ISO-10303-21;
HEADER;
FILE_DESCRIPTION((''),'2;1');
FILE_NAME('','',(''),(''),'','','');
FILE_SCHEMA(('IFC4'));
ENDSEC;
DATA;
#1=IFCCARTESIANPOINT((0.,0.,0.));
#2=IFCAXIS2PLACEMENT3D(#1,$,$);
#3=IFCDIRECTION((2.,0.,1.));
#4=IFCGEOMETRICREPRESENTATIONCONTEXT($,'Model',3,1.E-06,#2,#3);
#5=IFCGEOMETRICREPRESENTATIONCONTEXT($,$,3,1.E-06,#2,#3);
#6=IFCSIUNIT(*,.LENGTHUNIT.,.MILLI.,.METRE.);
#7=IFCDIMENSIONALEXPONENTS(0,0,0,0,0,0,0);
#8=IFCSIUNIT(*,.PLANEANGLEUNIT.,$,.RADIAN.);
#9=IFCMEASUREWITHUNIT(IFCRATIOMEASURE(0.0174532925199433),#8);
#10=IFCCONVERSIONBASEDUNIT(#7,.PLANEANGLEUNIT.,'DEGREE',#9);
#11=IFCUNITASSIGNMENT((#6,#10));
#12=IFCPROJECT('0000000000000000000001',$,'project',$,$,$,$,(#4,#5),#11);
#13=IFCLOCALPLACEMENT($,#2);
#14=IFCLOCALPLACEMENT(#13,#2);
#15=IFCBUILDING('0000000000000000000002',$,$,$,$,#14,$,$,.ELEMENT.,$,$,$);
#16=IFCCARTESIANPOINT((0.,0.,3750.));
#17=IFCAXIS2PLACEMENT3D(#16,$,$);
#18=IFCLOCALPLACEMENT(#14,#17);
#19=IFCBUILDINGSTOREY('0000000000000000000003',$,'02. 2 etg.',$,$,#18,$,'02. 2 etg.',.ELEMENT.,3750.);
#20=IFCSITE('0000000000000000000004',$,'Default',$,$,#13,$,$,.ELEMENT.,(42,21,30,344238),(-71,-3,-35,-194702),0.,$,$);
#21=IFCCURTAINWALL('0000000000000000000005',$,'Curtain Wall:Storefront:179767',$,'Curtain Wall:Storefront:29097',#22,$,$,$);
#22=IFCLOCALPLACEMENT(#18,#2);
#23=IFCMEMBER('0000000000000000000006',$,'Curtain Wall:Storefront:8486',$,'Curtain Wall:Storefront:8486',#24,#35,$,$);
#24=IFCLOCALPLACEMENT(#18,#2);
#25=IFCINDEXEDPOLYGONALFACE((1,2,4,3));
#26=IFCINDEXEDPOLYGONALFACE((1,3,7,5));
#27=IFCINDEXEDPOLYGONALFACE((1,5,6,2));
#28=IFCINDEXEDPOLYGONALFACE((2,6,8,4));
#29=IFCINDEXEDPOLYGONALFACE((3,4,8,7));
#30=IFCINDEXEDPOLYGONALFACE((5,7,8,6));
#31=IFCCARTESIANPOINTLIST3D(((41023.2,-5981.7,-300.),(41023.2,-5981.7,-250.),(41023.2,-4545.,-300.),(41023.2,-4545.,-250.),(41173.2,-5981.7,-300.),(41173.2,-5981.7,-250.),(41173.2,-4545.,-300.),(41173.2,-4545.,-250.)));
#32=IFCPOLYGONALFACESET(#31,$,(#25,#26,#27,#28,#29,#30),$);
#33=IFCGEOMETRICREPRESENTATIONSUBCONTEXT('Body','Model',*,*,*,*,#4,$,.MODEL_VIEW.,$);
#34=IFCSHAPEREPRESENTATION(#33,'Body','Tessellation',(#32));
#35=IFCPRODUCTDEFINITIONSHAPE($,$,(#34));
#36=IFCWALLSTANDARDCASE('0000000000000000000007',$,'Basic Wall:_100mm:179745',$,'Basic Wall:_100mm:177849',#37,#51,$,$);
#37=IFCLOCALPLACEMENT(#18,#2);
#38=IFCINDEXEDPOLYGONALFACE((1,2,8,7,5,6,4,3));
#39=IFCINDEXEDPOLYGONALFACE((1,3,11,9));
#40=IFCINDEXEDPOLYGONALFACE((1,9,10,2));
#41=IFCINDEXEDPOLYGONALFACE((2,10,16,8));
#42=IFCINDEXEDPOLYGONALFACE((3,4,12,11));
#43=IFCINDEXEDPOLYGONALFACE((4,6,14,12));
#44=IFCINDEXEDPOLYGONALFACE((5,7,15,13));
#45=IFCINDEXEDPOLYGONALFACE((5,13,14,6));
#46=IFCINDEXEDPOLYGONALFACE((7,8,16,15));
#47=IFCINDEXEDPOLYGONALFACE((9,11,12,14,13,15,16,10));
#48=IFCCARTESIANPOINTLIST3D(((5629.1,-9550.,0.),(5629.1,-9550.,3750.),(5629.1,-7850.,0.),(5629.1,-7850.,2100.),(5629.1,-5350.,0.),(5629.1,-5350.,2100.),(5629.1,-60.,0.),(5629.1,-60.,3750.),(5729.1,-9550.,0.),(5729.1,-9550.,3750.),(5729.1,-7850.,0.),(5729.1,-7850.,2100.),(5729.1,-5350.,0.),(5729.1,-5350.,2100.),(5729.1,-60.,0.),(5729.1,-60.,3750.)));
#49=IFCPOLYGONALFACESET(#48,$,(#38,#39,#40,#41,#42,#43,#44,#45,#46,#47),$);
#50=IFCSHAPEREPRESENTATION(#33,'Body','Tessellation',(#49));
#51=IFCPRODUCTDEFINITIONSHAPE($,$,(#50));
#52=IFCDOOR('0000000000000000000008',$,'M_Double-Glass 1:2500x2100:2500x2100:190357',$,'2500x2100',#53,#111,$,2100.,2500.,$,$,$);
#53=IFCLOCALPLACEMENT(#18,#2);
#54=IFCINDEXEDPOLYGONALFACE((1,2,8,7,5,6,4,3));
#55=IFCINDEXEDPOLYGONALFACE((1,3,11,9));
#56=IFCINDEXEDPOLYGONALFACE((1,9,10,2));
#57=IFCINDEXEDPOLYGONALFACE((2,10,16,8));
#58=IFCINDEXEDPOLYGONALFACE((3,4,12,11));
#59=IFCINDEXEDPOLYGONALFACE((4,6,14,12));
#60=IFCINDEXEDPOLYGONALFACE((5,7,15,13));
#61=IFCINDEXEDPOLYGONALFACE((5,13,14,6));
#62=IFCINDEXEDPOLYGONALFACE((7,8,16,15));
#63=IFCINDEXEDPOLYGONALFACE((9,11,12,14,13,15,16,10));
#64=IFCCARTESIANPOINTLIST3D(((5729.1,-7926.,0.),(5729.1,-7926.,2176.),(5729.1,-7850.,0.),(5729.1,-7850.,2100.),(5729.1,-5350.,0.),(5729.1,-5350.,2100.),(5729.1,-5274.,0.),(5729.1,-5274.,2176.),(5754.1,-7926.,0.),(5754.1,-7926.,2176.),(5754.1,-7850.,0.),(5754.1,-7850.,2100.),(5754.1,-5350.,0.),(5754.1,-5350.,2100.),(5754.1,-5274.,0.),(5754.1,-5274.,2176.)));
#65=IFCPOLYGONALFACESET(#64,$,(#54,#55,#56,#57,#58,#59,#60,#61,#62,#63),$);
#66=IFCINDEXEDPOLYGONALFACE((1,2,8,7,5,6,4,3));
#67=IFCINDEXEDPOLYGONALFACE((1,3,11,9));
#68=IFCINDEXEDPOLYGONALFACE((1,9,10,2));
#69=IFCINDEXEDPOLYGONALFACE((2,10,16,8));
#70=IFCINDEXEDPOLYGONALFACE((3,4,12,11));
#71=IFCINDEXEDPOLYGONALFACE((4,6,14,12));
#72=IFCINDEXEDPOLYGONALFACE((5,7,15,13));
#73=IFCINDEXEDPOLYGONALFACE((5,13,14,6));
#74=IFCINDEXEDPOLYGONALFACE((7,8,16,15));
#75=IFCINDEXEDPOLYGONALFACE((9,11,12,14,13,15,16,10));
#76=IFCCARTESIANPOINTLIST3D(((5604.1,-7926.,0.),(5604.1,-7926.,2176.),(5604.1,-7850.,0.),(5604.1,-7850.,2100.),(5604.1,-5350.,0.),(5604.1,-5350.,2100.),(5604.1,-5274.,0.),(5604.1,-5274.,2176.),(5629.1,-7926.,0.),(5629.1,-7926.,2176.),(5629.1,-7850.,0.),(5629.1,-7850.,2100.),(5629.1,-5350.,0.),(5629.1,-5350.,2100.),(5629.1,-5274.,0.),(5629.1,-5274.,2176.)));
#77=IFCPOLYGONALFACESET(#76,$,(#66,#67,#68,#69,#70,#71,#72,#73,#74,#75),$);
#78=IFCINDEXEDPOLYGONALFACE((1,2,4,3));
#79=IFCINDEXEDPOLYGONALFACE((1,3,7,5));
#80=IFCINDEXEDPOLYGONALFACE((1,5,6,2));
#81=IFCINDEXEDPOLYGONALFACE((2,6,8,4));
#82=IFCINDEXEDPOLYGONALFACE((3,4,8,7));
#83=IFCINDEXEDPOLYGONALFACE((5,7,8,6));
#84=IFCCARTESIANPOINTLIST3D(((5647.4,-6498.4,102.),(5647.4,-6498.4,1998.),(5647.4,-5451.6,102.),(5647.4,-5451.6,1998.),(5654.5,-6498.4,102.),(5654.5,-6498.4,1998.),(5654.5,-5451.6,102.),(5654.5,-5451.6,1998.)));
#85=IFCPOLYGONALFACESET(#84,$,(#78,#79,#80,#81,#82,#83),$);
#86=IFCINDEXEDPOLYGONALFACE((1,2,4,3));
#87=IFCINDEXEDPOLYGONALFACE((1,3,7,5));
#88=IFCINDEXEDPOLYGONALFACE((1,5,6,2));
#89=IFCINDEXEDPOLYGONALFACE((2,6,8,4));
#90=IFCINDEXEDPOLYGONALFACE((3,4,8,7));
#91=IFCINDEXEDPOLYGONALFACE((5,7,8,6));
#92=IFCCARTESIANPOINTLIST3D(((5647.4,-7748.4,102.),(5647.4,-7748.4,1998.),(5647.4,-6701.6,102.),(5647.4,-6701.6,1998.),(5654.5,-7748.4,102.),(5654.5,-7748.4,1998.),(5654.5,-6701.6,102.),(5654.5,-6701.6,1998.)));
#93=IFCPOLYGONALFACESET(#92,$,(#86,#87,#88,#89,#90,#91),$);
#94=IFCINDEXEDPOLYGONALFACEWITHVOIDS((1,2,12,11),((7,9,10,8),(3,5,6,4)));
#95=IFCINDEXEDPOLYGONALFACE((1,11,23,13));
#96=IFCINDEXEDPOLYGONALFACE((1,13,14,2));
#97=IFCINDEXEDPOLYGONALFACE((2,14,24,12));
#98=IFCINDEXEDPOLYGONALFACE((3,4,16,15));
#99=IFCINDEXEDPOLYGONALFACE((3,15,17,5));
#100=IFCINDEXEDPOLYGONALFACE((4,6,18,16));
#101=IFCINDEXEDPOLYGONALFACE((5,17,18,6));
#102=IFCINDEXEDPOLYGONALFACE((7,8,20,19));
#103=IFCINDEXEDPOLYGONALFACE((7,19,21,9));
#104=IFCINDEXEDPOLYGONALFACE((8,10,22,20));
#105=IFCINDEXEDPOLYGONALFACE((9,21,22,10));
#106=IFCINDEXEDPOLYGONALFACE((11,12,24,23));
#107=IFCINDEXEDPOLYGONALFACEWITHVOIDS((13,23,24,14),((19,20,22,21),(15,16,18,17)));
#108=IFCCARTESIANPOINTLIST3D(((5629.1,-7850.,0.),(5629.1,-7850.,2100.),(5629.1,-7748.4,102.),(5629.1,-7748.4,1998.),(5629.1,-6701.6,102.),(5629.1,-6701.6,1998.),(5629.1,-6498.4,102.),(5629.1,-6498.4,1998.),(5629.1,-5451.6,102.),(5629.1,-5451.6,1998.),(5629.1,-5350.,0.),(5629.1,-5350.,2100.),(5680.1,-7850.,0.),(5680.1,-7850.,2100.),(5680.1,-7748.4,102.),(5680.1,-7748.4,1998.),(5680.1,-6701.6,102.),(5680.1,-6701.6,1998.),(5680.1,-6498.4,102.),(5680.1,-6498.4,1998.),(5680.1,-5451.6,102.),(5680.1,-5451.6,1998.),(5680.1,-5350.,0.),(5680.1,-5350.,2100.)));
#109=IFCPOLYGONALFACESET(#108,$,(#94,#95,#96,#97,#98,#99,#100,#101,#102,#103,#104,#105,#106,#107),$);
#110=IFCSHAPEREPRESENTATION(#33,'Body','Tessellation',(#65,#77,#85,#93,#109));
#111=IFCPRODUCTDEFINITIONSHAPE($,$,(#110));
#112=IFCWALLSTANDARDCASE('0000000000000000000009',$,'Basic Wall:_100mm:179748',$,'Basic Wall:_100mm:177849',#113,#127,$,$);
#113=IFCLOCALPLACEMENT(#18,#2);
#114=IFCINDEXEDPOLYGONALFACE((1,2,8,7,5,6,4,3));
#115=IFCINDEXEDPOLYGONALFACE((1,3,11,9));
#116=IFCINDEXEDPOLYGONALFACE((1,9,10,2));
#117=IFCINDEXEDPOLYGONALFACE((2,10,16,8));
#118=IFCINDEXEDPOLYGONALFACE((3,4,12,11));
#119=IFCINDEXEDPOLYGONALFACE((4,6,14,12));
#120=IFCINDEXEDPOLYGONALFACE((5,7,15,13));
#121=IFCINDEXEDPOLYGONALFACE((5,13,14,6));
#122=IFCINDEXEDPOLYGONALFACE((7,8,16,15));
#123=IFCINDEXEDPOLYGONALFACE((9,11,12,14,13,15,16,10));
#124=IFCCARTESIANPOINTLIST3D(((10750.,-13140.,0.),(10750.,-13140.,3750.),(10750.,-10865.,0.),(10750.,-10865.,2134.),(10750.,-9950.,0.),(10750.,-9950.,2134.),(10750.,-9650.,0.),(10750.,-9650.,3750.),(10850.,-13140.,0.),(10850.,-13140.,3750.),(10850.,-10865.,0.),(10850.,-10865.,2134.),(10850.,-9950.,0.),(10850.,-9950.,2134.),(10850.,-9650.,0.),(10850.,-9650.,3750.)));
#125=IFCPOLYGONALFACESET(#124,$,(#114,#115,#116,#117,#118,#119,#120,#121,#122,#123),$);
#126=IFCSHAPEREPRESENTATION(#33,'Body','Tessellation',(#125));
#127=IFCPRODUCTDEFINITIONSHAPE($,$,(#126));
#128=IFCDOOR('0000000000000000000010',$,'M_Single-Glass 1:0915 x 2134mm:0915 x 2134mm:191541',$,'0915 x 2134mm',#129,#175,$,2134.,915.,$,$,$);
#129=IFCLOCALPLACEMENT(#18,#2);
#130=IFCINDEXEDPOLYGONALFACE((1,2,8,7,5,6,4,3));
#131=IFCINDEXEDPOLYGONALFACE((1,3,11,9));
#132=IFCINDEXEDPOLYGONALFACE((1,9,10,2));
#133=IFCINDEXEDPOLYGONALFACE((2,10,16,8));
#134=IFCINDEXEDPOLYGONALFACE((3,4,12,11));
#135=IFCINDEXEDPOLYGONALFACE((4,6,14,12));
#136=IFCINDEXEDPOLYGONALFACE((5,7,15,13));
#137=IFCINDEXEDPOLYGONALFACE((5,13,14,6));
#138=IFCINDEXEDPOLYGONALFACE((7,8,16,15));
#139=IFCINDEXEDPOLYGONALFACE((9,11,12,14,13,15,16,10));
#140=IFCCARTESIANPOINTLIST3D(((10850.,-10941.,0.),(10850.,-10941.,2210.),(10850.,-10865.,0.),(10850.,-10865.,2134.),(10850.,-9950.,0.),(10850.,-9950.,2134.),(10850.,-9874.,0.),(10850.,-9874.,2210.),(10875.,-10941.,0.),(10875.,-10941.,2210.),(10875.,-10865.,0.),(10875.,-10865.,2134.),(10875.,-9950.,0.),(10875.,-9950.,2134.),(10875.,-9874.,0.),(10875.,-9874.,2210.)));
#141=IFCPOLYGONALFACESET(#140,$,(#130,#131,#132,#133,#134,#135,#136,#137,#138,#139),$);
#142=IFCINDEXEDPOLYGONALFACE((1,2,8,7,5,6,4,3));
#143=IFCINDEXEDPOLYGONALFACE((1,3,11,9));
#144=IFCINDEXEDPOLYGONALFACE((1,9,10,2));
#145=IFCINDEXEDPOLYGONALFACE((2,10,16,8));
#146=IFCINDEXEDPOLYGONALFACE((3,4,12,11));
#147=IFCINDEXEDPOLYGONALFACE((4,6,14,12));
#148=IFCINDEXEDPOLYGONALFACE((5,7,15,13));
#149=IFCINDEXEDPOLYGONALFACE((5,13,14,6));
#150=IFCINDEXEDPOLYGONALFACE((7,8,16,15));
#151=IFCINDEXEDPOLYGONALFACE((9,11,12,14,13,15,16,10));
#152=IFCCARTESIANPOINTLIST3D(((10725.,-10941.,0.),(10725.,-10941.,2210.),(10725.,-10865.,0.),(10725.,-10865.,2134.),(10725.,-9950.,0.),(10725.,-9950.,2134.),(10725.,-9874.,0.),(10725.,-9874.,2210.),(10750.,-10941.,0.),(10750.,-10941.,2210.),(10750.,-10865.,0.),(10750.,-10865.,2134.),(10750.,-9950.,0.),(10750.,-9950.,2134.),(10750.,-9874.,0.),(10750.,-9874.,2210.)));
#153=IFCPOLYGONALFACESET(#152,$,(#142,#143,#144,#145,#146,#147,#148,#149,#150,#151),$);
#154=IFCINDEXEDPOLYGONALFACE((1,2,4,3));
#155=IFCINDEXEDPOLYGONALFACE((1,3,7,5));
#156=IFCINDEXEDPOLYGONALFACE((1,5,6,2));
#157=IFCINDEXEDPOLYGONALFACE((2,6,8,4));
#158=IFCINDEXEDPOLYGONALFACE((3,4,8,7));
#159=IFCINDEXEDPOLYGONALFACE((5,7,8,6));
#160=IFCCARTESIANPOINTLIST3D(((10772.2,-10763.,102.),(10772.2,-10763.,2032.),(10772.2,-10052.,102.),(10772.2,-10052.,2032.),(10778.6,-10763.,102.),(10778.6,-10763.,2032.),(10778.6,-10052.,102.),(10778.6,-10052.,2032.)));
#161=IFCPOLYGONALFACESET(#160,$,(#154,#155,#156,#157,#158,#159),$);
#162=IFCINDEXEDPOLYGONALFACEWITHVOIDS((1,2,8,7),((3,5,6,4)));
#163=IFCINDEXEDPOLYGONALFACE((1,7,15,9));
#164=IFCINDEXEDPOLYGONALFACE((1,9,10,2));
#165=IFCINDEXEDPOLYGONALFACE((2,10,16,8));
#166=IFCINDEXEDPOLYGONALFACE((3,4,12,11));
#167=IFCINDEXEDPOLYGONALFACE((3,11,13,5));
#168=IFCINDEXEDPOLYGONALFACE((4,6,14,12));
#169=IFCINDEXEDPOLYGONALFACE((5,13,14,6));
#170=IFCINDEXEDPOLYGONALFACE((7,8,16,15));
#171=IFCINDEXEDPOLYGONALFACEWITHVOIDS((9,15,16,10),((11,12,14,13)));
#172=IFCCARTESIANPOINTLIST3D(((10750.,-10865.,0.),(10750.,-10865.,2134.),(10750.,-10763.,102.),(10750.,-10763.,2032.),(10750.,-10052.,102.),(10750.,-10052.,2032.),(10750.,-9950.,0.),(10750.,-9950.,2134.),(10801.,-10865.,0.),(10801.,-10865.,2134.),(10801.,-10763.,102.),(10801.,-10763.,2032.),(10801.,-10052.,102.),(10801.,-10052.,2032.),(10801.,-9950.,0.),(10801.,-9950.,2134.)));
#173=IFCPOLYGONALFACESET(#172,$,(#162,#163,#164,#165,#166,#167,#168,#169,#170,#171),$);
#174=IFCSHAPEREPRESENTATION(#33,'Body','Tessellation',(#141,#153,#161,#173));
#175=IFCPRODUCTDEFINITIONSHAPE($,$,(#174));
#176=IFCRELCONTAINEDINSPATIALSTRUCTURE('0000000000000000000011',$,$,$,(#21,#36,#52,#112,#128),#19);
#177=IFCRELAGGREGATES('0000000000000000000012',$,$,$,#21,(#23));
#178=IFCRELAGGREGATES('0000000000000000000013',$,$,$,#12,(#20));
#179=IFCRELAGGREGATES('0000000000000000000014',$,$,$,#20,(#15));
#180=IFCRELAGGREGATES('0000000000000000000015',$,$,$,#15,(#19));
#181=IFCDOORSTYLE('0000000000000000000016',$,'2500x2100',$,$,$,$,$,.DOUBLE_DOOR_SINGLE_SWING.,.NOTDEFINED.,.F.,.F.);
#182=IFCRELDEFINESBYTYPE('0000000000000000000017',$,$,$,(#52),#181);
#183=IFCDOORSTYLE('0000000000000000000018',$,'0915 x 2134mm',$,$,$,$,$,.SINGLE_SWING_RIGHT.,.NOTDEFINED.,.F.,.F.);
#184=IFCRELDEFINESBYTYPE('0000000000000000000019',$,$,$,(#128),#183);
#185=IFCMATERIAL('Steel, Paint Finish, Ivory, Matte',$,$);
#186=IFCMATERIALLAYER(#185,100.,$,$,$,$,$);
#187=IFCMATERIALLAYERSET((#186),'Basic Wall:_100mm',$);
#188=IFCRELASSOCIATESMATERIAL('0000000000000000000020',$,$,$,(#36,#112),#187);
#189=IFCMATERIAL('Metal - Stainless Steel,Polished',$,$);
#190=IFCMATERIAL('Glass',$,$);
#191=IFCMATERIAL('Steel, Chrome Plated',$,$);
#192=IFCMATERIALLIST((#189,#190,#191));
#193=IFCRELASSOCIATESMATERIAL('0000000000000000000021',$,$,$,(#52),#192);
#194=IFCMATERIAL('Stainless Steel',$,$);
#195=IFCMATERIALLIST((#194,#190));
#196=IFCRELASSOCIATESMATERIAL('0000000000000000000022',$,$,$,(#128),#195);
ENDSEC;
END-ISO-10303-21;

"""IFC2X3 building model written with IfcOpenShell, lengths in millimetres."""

from ifc_helpers import new_model, entity, si_unit, converted_unit, direction, frame, frame_2d, origin, origin_2d_with_axis, place, context, subcontext, project, spatial, polyline, rectangle, outline, extrude, source, transform, mapped, material, material_list, layer, layer_set, layer_usage, type_object, type_shapes, element, fill, aggregate, save


model = new_model("IFC2X3")

# Units and contexts
model_context = context("Model", 3, precision=1e-06, world=origin(), true_north=direction((2.0, 0.0, 1.0)))
context_of_model = context(None, 3, precision=1e-06, world=origin(), true_north=direction((2.0, 0.0, 1.0)))
body_context = subcontext(model_context, "Body", "Model", "MODEL_VIEW")
ifc_project = project(units=[si_unit("LENGTHUNIT", "METRE", prefix="MILLI"), converted_unit("PLANEANGLEUNIT", "DEGREE", entity("IfcRatioMeasure", 0.0174532925199433), si_unit("PLANEANGLEUNIT", "RADIAN"), dimensions=[0, 0, 0, 0, 0, 0, 0])], contexts=[model_context, context_of_model])

# Site, building, storey
site_placement = place(None, origin())
site = spatial("IfcSite", under=ifc_project, at=site_placement, Name="Default", CompositionType="ELEMENT", RefLatitude=(42, 21, 30, 344238), RefLongitude=(-71, -3, -35, -194702), RefElevation=0.0)
building_placement = place(site_placement, origin())
building = spatial("IfcBuilding", under=site, at=building_placement, CompositionType="ELEMENT")
storey_placement = place(building_placement, frame((0.0, 0.0, 3750.0)))
storey = spatial("IfcBuildingStorey", under=building, at=storey_placement, Name="02. 2 etg.", LongName="02. 2 etg.", CompositionType="ELEMENT", Elevation=3750.0)

# Curtain wall, member
curtain_wall_1_placement = place(storey_placement, origin())
curtain_wall_1 = element("IfcCurtainWall", 1, at=curtain_wall_1_placement, inside=storey, Name="Curtain Wall:Storefront:179767", ObjectType="Curtain Wall:Storefront:29097")
member_placement = place(storey_placement, origin())
member = element("IfcMember", 2, at=member_placement, Name="Curtain Wall:Storefront:8486", ObjectType="Curtain Wall:Storefront:8486", context=body_context, shape_type="SweptSolid", body=[
    extrude(rectangle(XDim=1436.7, YDim=150.0, at=origin_2d_with_axis()), frame((41098.2, -5263.3, -300.0), z_axis=(0.0, 0.0, 1.0), x_axis=(0.0, -1.0, 0.0)), (0.0, 0.0, 1.0), 50.0),
])
aggregate(curtain_wall_1, [member])

# Shared definitions
ifc_material_1 = material(Name="Glass")

# Walls, openings, doors
ifc_material_2 = material(Name="Steel, Paint Finish, Ivory, Matte")
ifc_layer_1 = layer(ifc_material_2, 100.0)
ifc_layer_set_1 = layer_set([ifc_layer_1], Name="Basic Wall:_100mm")
ifc_layer_usage_1 = layer_usage(ifc_layer_set_1, "AXIS2", "NEGATIVE", 50.0)
wall_1_placement = place(storey_placement, frame((5679.1, -9550.0, 0.0), z_axis=(0.0, 0.0, 1.0), x_axis=(0.0, 1.0, 0.0)))
wall_1 = element("IfcWallStandardCase", 3, at=wall_1_placement, inside=storey, material=ifc_layer_usage_1, Name="Basic Wall:_100mm:179745", ObjectType="Basic Wall:_100mm:177849", context=body_context, shape_type="SweptSolid", body=[
    extrude(rectangle(XDim=9490.0, YDim=100.0, at=frame_2d((4745.0, 0.0), x_axis=(-1.0, 0.0))), origin(), (0.0, 0.0, 1.0), 3750.0),
])
opening_1_placement = place(wall_1_placement, frame((1700.0, -50.0, 0.0)))
opening_1 = element("IfcOpeningElement", 4, at=opening_1_placement, cuts=wall_1, ObjectType="Opening", context=body_context, shape_type="SweptSolid", body=[
    extrude(rectangle(XDim=2500.0, YDim=2100.0, at=frame_2d((1050.0, 1250.0), x_axis=(0.0, 1.0))), frame((0.0, 0.0, 0.0), z_axis=(0.0, 1.0, 0.0), x_axis=(0.0, 0.0, 1.0)), (0.0, 0.0, 1.0), 100.0),
])
ifc_material_3 = material(Name="Metal - Stainless Steel,Polished")
ifc_material_4 = material(Name="Steel, Chrome Plated")
ifc_material_list_1 = material_list([ifc_material_3, ifc_material_1, ifc_material_4])
door_style_1 = type_object("IfcDoorStyle", Name="2500x2100", ConstructionType="NOTDEFINED", OperationType="DOUBLE_DOOR_SINGLE_SWING", ParameterTakesPrecedence=False, Sizeable=False)
shared_shape_1 = source(origin(), body_context, "Body", "SweptSolid", [
    extrude(outline(polyline([(-1326.0, -1069.0), (-1250.0, -1069.0), (-1250.0, 1031.0), (1250.0, 1031.0), (1250.0, -1069.0), (1326.0, -1069.0), (1326.0, 1107.0), (-1326.0, 1107.0), (-1326.0, -1069.0)])), frame((1250.0, -25.0, 1069.0), z_axis=(0.0, 1.0, 0.0), x_axis=(-1.0, 0.0, 0.0)), (0.0, 0.0, 1.0), 25.0),
    extrude(outline(polyline([(-1250.0, -1031.0), (-1250.0, 1069.0), (-1326.0, 1069.0), (-1326.0, -1107.0), (1326.0, -1107.0), (1326.0, 1069.0), (1250.0, 1069.0), (1250.0, -1031.0), (-1250.0, -1031.0)])), frame((1250.0, 100.0, 1069.0), z_axis=(0.0, -1.0, 0.0), x_axis=(-1.0, 0.0, 0.0)), (0.0, 0.0, -1.0), 25.0),
    extrude(rectangle(XDim=7.1, YDim=1046.8, at=frame_2d((0.0, 0.0), x_axis=(1.0, 0.0))), frame((1875.0, 78.2, 102.0), z_axis=(0.0, 0.0, 1.0), x_axis=(0.0, 1.0, 0.0)), (0.0, 0.0, 1.0), 1896.0),
    extrude(rectangle(XDim=7.1, YDim=1046.8, at=frame_2d((0.0, 0.0), x_axis=(1.0, 0.0))), frame((625.0, 78.2, 102.0), z_axis=(0.0, 0.0, 1.0), x_axis=(0.0, 1.0, 0.0)), (0.0, 0.0, 1.0), 1896.0),
    extrude(outline(polyline([(-1050.0, -1250.0), (1050.0, -1250.0), (1050.0, 1250.0), (-1050.0, 1250.0), (-1050.0, -1250.0)]), holes=[polyline([(-948.0, 101.6), (-948.0, 1148.4), (948.0, 1148.4), (948.0, 101.6), (-948.0, 101.6)]), polyline([(-948.0, -1148.4), (-948.0, -101.6), (948.0, -101.6), (948.0, -1148.4), (-948.0, -1148.4)])]), frame((1250.0, 49.0, 1050.0), z_axis=(0.0, 1.0, 0.0), x_axis=(0.0, 0.0, -1.0)), (0.0, 0.0, 1.0), 51.0),
])
type_shapes(door_style_1, [shared_shape_1])
door_1_placement = place(opening_1_placement, origin())
door_1 = element("IfcDoor", 5, at=door_1_placement, inside=storey, type_object=door_style_1, material=ifc_material_list_1, Name="M_Double-Glass 1:2500x2100:2500x2100:190357", ObjectType="2500x2100", OverallHeight=2100.0, OverallWidth=2500.0, context=body_context, shape_type="MappedRepresentation", body=[
    mapped(shared_shape_1, transform((0.0, 0.0, 0.0), scale=1.0)),
])
fill(opening_1, door_1)
ifc_layer_usage_2 = layer_usage(ifc_layer_set_1, "AXIS2", "NEGATIVE", 50.0)
wall_2_placement = place(storey_placement, frame((10800.0, -13140.0, 0.0), z_axis=(0.0, 0.0, 1.0), x_axis=(0.0, 1.0, 0.0)))
wall_2 = element("IfcWallStandardCase", 6, at=wall_2_placement, inside=storey, material=ifc_layer_usage_2, Name="Basic Wall:_100mm:179748", ObjectType="Basic Wall:_100mm:177849", context=body_context, shape_type="SweptSolid", body=[
    extrude(rectangle(XDim=3490.0, YDim=100.0, at=frame_2d((1745.0, 0.0), x_axis=(-1.0, 0.0))), origin(), (0.0, 0.0, 1.0), 3750.0),
])
opening_2_placement = place(wall_2_placement, frame((2275.0, -50.0, 0.0)))
opening_2 = element("IfcOpeningElement", 7, at=opening_2_placement, cuts=wall_2, ObjectType="Opening", context=body_context, shape_type="SweptSolid", body=[
    extrude(rectangle(XDim=915.0, YDim=2134.0, at=frame_2d((1067.0, 457.5), x_axis=(0.0, 1.0))), frame((0.0, 0.0, 0.0), z_axis=(0.0, 1.0, 0.0), x_axis=(0.0, 0.0, 1.0)), (0.0, 0.0, 1.0), 100.0),
])
ifc_material_5 = material(Name="Stainless Steel")
ifc_material_list_2 = material_list([ifc_material_5, ifc_material_1])
door_style_2 = type_object("IfcDoorStyle", Name="0915 x 2134mm", ConstructionType="NOTDEFINED", OperationType="SINGLE_SWING_RIGHT", ParameterTakesPrecedence=False, Sizeable=False)
shared_shape_2 = source(origin(), body_context, "Body", "SweptSolid", [
    extrude(outline(polyline([(-457.5, -1048.0), (-457.5, 1086.0), (-533.5, 1086.0), (-533.5, -1124.0), (533.5, -1124.0), (533.5, 1086.0), (457.5, 1086.0), (457.5, -1048.0), (-457.5, -1048.0)])), frame((457.5, -25.0, 1086.0), z_axis=(0.0, -1.0, 0.0), x_axis=(-1.0, 0.0, 0.0)), (0.0, 0.0, -1.0), 25.0),
    extrude(outline(polyline([(-457.5, -1048.0), (-457.5, 1086.0), (-533.5, 1086.0), (-533.5, -1124.0), (533.5, -1124.0), (533.5, 1086.0), (457.5, 1086.0), (457.5, -1048.0), (-457.5, -1048.0)])), frame((457.5, 100.0, 1086.0), z_axis=(0.0, -1.0, 0.0), x_axis=(-1.0, 0.0, 0.0)), (0.0, 0.0, -1.0), 25.0),
    extrude(rectangle(XDim=6.3, YDim=711.0, at=frame_2d((0.0, 0.0), x_axis=(1.0, 0.0))), frame((457.5, 74.6, 102.0), z_axis=(0.0, 0.0, 1.0), x_axis=(0.0, 1.0, 0.0)), (0.0, 0.0, 1.0), 1930.0),
    extrude(outline(polyline([(-1067.0, -457.5), (1067.0, -457.5), (1067.0, 457.5), (-1067.0, 457.5), (-1067.0, -457.5)]), holes=[polyline([(-965.0, 355.5), (965.0, 355.5), (965.0, -355.5), (-965.0, -355.5), (-965.0, 355.5)])]), frame((457.5, 49.0, 1067.0), z_axis=(0.0, 1.0, 0.0), x_axis=(0.0, 0.0, -1.0)), (0.0, 0.0, 1.0), 51.0),
])
type_shapes(door_style_2, [shared_shape_2])
door_2_placement = place(opening_2_placement, origin())
door_2 = element("IfcDoor", 8, at=door_2_placement, inside=storey, type_object=door_style_2, material=ifc_material_list_2, Name="M_Single-Glass 1:0915 x 2134mm:0915 x 2134mm:191541", ObjectType="0915 x 2134mm", OverallHeight=2134.0, OverallWidth=915.0, context=body_context, shape_type="MappedRepresentation", body=[
    mapped(shared_shape_2, transform((0.0, 0.0, 0.0), scale=1.0)),
])
fill(opening_2, door_2)

save(model, "model.ifc")
